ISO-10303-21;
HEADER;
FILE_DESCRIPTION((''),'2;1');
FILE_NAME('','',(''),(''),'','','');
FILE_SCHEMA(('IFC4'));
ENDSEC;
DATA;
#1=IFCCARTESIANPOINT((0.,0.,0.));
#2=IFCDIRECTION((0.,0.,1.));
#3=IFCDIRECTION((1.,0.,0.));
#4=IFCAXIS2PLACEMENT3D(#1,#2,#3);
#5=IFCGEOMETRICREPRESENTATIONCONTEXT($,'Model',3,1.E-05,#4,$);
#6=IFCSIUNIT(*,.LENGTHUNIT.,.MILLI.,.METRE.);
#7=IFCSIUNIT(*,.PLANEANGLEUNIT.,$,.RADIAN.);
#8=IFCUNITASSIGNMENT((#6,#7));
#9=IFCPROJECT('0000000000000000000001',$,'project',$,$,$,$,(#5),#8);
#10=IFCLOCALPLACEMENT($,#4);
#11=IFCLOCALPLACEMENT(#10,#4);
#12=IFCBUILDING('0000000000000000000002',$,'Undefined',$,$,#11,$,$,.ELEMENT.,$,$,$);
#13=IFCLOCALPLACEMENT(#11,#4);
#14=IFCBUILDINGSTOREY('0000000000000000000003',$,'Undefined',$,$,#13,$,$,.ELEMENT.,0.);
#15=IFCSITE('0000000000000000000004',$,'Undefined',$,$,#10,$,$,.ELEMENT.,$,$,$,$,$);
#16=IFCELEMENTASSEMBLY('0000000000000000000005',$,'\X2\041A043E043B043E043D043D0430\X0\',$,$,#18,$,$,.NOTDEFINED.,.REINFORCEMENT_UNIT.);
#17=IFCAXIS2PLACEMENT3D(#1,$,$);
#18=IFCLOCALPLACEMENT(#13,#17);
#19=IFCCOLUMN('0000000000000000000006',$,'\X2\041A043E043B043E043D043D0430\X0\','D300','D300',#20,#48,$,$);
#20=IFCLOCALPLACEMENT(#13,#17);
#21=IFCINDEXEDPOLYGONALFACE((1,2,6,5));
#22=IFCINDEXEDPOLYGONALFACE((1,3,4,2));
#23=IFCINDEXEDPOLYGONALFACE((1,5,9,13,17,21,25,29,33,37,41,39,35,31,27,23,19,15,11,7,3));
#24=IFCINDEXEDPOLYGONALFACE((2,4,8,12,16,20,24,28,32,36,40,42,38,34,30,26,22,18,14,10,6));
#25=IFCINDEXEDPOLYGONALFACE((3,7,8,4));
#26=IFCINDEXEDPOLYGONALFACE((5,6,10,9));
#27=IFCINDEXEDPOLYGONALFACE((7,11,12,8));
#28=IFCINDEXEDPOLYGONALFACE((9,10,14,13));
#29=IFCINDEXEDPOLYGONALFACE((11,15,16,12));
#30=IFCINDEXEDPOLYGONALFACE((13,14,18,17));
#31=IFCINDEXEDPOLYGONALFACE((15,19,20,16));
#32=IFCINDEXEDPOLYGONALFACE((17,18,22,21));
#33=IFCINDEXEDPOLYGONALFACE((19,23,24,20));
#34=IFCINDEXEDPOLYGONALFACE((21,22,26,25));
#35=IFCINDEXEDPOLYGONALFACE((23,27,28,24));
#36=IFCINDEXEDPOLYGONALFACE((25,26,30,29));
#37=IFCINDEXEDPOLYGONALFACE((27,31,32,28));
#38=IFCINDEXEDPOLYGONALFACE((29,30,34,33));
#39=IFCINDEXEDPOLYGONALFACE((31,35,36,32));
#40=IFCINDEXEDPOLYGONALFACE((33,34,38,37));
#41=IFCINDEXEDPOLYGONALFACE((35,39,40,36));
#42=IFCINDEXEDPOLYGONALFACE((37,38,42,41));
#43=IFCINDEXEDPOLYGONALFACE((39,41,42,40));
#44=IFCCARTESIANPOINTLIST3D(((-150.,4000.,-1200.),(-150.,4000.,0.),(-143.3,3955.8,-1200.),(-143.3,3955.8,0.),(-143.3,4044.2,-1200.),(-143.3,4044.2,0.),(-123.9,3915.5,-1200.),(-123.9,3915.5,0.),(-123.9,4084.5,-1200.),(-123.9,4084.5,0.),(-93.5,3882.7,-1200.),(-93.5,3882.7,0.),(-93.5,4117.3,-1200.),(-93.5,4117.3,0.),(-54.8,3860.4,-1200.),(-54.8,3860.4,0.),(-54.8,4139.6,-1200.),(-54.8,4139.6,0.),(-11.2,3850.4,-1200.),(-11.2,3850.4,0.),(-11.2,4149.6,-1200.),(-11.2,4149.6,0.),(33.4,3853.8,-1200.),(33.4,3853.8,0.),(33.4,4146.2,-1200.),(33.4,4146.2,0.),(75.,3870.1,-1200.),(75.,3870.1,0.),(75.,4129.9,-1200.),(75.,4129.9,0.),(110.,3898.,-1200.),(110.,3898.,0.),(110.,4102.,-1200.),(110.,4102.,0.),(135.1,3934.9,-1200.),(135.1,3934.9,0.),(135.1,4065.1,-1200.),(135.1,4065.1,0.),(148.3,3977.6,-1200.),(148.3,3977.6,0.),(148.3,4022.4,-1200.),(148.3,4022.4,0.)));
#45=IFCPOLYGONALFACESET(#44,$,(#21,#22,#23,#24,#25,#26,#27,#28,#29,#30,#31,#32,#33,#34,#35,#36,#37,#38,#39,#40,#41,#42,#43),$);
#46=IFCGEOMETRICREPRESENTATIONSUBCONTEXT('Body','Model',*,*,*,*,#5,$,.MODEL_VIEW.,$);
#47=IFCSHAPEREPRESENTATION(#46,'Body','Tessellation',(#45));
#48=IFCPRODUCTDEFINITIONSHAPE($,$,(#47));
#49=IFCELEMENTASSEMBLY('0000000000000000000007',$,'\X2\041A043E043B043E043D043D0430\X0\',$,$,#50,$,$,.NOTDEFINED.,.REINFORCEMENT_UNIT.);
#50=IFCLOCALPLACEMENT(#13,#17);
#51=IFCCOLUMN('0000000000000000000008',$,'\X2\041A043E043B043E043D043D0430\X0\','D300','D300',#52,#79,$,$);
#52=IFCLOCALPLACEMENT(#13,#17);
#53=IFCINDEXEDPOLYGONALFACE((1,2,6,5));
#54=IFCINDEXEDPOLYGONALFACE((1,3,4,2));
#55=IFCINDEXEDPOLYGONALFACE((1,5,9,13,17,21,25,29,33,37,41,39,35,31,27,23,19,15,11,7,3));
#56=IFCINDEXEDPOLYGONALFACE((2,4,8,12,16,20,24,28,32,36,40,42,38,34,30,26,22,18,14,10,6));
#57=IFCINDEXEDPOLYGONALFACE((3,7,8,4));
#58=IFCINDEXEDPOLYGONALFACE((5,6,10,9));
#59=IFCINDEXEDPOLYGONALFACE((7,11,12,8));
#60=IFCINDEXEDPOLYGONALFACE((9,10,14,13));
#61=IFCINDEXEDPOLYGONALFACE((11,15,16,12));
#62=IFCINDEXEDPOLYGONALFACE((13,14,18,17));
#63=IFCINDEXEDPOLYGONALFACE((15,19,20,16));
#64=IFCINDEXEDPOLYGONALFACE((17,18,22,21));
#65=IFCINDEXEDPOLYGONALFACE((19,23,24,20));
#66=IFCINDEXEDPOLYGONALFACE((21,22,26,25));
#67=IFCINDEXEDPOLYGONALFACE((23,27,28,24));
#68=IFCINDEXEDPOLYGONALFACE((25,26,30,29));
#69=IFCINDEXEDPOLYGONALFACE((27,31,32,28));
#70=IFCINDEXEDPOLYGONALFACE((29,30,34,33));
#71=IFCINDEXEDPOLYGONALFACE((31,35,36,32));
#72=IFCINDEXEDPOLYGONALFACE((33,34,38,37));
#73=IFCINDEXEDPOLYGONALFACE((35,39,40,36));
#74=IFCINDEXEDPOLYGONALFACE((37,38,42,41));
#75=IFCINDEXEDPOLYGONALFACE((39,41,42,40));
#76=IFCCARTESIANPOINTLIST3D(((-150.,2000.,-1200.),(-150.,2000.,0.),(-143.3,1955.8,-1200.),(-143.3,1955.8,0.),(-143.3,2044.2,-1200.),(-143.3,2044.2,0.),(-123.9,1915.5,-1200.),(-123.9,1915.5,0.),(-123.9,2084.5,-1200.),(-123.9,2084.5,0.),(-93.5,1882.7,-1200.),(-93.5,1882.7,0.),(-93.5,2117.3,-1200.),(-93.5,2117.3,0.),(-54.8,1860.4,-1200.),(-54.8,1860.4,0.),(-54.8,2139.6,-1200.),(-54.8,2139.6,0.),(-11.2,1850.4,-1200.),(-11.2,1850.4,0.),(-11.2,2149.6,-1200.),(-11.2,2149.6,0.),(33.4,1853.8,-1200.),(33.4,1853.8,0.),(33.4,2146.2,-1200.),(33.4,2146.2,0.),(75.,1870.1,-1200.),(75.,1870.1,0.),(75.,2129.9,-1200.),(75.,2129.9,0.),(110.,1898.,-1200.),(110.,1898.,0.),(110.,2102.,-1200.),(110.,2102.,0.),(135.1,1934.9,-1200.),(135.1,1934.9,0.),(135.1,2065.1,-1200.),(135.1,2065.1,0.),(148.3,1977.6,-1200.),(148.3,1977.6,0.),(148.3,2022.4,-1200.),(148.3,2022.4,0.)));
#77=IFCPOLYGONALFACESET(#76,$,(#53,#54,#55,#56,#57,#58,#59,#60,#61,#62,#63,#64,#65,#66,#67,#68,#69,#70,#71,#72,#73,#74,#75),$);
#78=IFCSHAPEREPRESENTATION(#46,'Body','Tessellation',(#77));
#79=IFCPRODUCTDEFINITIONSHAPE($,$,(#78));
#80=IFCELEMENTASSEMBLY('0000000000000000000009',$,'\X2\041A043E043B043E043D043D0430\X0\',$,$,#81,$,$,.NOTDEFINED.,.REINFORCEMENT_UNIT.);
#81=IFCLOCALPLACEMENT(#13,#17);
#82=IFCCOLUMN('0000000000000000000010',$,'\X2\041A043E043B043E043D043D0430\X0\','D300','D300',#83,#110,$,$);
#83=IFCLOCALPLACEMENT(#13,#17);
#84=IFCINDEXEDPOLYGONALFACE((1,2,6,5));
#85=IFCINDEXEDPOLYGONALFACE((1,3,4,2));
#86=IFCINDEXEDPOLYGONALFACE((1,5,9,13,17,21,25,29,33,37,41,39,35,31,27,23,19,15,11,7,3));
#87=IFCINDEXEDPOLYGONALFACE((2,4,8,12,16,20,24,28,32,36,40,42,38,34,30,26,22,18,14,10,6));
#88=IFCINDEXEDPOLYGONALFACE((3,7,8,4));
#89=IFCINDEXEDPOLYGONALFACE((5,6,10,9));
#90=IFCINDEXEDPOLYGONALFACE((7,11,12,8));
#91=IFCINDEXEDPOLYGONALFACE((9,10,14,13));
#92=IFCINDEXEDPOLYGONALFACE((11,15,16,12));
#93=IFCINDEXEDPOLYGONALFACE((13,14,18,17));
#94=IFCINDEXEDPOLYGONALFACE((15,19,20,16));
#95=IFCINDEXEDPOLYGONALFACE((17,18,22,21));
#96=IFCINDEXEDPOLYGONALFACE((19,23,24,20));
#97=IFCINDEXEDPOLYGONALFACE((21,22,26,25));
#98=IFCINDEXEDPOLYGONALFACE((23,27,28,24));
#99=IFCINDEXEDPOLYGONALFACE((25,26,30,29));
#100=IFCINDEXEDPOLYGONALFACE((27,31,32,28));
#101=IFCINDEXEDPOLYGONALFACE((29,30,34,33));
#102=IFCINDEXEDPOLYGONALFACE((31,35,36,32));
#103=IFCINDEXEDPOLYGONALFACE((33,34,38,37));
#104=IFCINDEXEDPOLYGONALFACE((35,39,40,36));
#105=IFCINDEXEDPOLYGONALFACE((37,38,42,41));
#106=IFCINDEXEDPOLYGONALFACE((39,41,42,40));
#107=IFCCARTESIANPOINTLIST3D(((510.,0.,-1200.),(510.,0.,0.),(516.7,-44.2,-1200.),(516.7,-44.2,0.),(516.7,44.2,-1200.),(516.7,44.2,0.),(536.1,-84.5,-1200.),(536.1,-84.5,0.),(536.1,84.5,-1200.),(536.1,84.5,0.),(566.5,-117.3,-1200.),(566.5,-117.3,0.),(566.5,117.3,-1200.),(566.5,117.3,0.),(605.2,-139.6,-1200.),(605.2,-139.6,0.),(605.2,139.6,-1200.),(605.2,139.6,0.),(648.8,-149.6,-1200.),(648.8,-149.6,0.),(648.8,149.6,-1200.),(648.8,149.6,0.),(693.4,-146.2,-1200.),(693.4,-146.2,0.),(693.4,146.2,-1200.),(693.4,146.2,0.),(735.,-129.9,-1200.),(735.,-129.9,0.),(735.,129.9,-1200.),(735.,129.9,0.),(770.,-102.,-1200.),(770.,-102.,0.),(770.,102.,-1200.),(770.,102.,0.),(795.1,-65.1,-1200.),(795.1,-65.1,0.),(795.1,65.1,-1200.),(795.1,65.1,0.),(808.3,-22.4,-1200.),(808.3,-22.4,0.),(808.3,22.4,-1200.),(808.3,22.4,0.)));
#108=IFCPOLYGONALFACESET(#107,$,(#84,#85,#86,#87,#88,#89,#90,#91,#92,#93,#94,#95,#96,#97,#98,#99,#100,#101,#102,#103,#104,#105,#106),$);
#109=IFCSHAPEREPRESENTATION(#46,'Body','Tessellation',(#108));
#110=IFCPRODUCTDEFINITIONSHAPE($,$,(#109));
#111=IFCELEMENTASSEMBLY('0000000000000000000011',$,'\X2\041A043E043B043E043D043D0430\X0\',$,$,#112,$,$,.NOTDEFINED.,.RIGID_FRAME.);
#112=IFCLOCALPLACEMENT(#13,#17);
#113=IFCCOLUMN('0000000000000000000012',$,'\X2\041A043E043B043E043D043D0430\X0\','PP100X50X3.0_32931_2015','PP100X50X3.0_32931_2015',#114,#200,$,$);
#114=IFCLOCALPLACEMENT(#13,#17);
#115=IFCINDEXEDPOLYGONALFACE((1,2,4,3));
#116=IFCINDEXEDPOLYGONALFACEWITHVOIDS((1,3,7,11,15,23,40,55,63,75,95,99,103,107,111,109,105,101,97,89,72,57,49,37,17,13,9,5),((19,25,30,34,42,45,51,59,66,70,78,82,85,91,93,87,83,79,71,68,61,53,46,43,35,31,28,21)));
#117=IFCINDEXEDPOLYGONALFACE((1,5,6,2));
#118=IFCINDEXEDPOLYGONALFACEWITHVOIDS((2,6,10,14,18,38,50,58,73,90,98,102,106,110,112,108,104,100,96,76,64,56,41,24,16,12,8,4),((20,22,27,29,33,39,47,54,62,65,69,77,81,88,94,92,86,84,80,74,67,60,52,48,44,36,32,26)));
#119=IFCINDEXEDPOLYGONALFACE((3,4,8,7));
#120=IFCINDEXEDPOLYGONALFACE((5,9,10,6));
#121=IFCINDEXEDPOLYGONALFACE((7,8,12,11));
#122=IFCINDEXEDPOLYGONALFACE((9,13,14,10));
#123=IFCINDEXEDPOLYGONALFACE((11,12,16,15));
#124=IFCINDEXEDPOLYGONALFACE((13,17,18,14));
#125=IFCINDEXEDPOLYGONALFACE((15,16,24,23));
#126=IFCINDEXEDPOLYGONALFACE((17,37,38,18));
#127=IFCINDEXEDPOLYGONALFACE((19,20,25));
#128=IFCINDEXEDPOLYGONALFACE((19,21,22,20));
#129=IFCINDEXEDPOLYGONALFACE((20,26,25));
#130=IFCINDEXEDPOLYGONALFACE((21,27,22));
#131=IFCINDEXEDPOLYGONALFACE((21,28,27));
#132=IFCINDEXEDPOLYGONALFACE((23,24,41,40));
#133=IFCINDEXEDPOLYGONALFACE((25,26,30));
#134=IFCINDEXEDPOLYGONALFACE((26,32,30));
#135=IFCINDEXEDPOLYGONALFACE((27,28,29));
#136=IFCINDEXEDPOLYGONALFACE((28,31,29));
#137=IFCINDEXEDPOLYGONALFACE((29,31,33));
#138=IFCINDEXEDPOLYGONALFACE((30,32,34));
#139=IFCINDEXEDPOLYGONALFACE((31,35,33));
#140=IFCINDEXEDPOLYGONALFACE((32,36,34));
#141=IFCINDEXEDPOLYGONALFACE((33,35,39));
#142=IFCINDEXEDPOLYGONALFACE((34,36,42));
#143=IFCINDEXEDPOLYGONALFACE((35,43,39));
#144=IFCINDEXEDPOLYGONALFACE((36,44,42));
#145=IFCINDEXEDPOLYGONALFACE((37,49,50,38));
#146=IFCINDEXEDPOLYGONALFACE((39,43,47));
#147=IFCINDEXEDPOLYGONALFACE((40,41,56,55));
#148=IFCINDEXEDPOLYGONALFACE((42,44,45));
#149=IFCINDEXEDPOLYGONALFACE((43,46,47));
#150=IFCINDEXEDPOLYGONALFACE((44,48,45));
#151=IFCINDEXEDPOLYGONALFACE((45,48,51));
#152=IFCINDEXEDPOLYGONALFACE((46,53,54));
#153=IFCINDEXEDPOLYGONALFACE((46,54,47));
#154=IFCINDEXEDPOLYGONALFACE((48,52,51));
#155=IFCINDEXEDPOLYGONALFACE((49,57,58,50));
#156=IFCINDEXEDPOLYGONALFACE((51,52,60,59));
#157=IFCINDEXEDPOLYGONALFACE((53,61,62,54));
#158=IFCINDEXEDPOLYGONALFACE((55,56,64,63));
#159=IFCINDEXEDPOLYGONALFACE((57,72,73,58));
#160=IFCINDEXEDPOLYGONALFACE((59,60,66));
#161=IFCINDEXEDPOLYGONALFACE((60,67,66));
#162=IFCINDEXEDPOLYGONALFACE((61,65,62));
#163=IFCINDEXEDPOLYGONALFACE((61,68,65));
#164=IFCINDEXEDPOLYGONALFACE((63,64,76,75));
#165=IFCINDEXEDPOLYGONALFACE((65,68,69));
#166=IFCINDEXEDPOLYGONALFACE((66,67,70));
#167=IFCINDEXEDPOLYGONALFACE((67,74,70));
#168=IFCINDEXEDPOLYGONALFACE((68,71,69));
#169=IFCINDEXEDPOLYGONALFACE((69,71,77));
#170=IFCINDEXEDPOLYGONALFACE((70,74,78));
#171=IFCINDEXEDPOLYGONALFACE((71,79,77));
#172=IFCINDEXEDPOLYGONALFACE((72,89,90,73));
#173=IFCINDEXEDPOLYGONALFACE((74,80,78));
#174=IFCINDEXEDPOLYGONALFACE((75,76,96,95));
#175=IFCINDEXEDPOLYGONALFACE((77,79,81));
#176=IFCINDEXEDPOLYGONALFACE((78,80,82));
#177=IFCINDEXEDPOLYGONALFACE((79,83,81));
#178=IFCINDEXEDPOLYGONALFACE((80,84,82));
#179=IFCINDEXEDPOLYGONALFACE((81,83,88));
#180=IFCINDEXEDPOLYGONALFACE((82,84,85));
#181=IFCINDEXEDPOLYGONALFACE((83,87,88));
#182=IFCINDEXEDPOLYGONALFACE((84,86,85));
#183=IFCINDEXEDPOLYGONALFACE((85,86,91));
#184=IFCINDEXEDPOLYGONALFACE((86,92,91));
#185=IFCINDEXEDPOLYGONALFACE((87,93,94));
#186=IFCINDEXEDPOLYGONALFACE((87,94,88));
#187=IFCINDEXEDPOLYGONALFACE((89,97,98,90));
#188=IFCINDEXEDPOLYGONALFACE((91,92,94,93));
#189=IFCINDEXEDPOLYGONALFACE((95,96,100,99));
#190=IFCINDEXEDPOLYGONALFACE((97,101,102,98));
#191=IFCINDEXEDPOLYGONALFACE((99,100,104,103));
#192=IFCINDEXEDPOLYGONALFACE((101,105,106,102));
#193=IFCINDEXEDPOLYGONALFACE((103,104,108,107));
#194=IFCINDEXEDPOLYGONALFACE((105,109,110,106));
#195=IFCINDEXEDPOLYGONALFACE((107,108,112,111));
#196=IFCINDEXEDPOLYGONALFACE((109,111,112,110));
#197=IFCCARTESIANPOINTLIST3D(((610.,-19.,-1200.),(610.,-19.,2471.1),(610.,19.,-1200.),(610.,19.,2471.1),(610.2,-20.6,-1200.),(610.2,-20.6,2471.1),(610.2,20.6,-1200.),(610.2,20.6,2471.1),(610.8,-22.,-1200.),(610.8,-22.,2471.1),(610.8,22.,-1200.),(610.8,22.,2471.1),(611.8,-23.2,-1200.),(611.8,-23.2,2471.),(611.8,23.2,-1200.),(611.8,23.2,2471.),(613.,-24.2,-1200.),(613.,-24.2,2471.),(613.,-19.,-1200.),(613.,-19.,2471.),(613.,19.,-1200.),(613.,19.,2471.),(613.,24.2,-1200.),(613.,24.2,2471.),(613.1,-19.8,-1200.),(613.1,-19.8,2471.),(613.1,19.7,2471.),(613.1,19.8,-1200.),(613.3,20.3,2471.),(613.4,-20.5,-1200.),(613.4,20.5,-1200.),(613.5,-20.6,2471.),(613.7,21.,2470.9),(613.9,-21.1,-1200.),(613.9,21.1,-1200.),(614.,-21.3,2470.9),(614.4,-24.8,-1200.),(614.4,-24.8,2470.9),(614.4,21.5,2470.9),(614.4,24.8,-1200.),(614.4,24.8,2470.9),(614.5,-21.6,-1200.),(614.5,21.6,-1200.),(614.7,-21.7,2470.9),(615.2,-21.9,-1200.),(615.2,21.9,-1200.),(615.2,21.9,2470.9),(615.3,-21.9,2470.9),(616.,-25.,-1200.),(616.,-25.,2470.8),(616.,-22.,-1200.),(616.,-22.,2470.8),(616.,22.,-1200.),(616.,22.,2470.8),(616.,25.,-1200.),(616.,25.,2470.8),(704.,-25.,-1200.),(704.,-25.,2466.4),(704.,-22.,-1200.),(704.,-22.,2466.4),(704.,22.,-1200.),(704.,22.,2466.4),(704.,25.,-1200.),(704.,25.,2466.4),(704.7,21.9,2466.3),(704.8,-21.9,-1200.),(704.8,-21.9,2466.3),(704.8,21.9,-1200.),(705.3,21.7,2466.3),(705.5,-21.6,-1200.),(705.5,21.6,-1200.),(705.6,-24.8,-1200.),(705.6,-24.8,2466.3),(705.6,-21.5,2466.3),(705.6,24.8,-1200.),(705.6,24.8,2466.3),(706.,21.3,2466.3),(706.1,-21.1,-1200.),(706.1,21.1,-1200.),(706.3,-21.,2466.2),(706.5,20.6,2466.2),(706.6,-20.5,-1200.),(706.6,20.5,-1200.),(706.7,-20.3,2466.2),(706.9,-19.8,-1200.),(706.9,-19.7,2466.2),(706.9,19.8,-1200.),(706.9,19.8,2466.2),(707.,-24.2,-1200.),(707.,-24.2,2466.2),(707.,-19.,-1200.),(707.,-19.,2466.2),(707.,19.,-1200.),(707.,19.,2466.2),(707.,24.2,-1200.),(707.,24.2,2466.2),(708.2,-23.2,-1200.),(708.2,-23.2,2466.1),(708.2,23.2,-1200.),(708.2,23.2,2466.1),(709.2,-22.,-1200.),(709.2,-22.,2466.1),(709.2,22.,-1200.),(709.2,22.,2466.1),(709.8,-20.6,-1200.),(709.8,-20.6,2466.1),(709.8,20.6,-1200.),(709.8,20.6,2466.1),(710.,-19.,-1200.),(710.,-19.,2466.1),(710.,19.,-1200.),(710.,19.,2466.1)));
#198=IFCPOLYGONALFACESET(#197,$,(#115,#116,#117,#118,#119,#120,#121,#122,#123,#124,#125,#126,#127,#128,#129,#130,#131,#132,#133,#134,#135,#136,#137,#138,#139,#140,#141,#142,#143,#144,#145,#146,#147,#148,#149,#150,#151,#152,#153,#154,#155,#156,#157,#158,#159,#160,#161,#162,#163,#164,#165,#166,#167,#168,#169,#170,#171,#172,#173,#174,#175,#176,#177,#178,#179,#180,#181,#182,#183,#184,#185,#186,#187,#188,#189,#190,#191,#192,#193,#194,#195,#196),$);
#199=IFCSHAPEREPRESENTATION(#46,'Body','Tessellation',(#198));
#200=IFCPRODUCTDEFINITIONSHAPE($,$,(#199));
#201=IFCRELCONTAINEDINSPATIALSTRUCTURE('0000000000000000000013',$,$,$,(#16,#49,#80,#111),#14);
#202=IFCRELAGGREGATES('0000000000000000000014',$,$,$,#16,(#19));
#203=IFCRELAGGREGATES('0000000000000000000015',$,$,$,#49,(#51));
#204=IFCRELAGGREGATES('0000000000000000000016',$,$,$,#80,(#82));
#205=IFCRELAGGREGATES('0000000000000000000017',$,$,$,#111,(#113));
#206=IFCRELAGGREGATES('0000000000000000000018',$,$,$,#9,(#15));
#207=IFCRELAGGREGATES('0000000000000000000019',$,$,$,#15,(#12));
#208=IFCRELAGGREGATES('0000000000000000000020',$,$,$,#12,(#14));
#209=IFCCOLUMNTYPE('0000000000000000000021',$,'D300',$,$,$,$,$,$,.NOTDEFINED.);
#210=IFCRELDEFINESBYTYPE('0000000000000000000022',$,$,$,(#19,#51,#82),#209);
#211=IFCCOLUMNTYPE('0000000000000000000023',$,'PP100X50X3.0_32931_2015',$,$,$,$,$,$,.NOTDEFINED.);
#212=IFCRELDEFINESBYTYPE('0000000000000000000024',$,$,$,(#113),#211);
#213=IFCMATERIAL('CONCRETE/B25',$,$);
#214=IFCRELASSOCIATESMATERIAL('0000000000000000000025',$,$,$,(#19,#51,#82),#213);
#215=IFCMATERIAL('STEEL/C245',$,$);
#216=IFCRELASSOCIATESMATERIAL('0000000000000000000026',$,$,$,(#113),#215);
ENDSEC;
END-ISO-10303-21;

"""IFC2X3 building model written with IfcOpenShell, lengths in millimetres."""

from ifc_helpers import new_model, si_unit, frame, origin_with_axes, origin_2d_with_axis, place, context, subcontext, project, spatial, hollow_rectangle, circle, extrude, clip, halfspace, material, type_object, element, aggregate, save


model = new_model("IFC2X3")

# Units and contexts
model_context = context("Model", 3, precision=1e-05, world=origin_with_axes())
body_context = subcontext(model_context, "Body", "Model", "MODEL_VIEW")
ifc_project = project(units=[si_unit("LENGTHUNIT", "METRE", prefix="MILLI"), si_unit("PLANEANGLEUNIT", "RADIAN")], contexts=[model_context])

# Site, building, storey
site_placement = place(None, origin_with_axes())
site = spatial("IfcSite", under=ifc_project, at=site_placement, Name="Undefined", CompositionType="ELEMENT")
building_placement = place(site_placement, origin_with_axes())
building = spatial("IfcBuilding", under=site, at=building_placement, Name="Undefined", CompositionType="ELEMENT")
storey_placement = place(building_placement, origin_with_axes())
storey = spatial("IfcBuildingStorey", under=building, at=storey_placement, Name="Undefined", CompositionType="ELEMENT", Elevation=0.0)

# Element assemblies, columns
assembly_1_placement = place(storey_placement, origin_with_axes())
assembly_1 = element("IfcElementAssembly", 1, at=assembly_1_placement, inside=storey, Name="Колонна", AssemblyPlace="NOTDEFINED", PredefinedType="REINFORCEMENT_UNIT")
ifc_material_1 = material(Name="CONCRETE/B25")
column_type_1 = type_object("IfcColumnType", Name="D300", PredefinedType="NOTDEFINED")
column_1_placement = place(assembly_1_placement, frame((0.0, 4000.0, -1200.0), z_axis=(0.0, 0.0, 1.0), x_axis=(0.0, 1.0, 0.0)))
column_1 = element("IfcColumn", 2, at=column_1_placement, type_object=column_type_1, material=ifc_material_1, Name="Колонна", Description="D300", ObjectType="D300", context=body_context, shape_type="SweptSolid", body=[
    extrude(circle(Radius=150.0, at=origin_2d_with_axis()), frame((0.0, 0.0, 1200.0), z_axis=(0.0, 0.0, -1.0), x_axis=(0.0, 1.0, 0.0)), (0.0, 0.0, 1.0), 1200.0),
])
aggregate(assembly_1, [column_1])
assembly_2_placement = place(storey_placement, origin_with_axes())
assembly_2 = element("IfcElementAssembly", 3, at=assembly_2_placement, inside=storey, Name="Колонна", AssemblyPlace="NOTDEFINED", PredefinedType="REINFORCEMENT_UNIT")
column_2_placement = place(assembly_2_placement, frame((0.0, 2000.0, -1200.0), z_axis=(0.0, 0.0, 1.0), x_axis=(0.0, 1.0, 0.0)))
column_2 = element("IfcColumn", 4, at=column_2_placement, type_object=column_type_1, material=ifc_material_1, Name="Колонна", Description="D300", ObjectType="D300", context=body_context, shape_type="SweptSolid", body=[
    extrude(circle(Radius=150.0, at=origin_2d_with_axis()), frame((0.0, 0.0, 1200.0), z_axis=(0.0, 0.0, -1.0), x_axis=(0.0, 1.0, 0.0)), (0.0, 0.0, 1.0), 1200.0),
])
aggregate(assembly_2, [column_2])
assembly_3_placement = place(storey_placement, origin_with_axes())
assembly_3 = element("IfcElementAssembly", 5, at=assembly_3_placement, inside=storey, Name="Колонна", AssemblyPlace="NOTDEFINED", PredefinedType="REINFORCEMENT_UNIT")
column_3_placement = place(assembly_3_placement, frame((660.0, 0.0, -1200.0), z_axis=(0.0, 0.0, 1.0), x_axis=(0.0, 1.0, 0.0)))
column_3 = element("IfcColumn", 6, at=column_3_placement, type_object=column_type_1, material=ifc_material_1, Name="Колонна", Description="D300", ObjectType="D300", context=body_context, shape_type="SweptSolid", body=[
    extrude(circle(Radius=150.0, at=origin_2d_with_axis()), frame((0.0, 0.0, 1200.0), z_axis=(0.0, 0.0, -1.0), x_axis=(0.0, 1.0, 0.0)), (0.0, 0.0, 1.0), 1200.0),
])
aggregate(assembly_3, [column_3])
assembly_4_placement = place(storey_placement, origin_with_axes())
assembly_4 = element("IfcElementAssembly", 7, at=assembly_4_placement, inside=storey, Name="Колонна", AssemblyPlace="NOTDEFINED", PredefinedType="RIGID_FRAME")
ifc_material_2 = material(Name="STEEL/C245")
column_type_2 = type_object("IfcColumnType", Name="PP100X50X3.0_32931_2015", PredefinedType="NOTDEFINED")
column_4_placement = place(assembly_4_placement, frame((660.0, 0.0, -1200.0), z_axis=(0.0, 0.0, 1.0), x_axis=(-1.0, 0.0, 0.0)))
column_4 = element("IfcColumn", 8, at=column_4_placement, type_object=column_type_2, material=ifc_material_2, Name="Колонна", Description="PP100X50X3.0_32931_2015", ObjectType="PP100X50X3.0_32931_2015", context=body_context, shape_type="Clipping", body=[
    clip(extrude(hollow_rectangle(XDim=50.0, YDim=100.0, WallThickness=3.0, InnerFilletRadius=3.0, OuterFilletRadius=6.0, at=origin_2d_with_axis()), frame((0.0, 0.0, 3671.2), z_axis=(0.0, 0.0, -1.0), x_axis=(0.0, 1.0, 0.0)), (0.0, 0.0, 1.0), 3671.2), halfspace(frame((77.9, 0.0, 3672.6), z_axis=(-0.050782, 0.0, 0.99871), x_axis=(0.0, 1.0, 0.0)), False)),
])
aggregate(assembly_4, [column_4])

save(model, "model.ifc")
